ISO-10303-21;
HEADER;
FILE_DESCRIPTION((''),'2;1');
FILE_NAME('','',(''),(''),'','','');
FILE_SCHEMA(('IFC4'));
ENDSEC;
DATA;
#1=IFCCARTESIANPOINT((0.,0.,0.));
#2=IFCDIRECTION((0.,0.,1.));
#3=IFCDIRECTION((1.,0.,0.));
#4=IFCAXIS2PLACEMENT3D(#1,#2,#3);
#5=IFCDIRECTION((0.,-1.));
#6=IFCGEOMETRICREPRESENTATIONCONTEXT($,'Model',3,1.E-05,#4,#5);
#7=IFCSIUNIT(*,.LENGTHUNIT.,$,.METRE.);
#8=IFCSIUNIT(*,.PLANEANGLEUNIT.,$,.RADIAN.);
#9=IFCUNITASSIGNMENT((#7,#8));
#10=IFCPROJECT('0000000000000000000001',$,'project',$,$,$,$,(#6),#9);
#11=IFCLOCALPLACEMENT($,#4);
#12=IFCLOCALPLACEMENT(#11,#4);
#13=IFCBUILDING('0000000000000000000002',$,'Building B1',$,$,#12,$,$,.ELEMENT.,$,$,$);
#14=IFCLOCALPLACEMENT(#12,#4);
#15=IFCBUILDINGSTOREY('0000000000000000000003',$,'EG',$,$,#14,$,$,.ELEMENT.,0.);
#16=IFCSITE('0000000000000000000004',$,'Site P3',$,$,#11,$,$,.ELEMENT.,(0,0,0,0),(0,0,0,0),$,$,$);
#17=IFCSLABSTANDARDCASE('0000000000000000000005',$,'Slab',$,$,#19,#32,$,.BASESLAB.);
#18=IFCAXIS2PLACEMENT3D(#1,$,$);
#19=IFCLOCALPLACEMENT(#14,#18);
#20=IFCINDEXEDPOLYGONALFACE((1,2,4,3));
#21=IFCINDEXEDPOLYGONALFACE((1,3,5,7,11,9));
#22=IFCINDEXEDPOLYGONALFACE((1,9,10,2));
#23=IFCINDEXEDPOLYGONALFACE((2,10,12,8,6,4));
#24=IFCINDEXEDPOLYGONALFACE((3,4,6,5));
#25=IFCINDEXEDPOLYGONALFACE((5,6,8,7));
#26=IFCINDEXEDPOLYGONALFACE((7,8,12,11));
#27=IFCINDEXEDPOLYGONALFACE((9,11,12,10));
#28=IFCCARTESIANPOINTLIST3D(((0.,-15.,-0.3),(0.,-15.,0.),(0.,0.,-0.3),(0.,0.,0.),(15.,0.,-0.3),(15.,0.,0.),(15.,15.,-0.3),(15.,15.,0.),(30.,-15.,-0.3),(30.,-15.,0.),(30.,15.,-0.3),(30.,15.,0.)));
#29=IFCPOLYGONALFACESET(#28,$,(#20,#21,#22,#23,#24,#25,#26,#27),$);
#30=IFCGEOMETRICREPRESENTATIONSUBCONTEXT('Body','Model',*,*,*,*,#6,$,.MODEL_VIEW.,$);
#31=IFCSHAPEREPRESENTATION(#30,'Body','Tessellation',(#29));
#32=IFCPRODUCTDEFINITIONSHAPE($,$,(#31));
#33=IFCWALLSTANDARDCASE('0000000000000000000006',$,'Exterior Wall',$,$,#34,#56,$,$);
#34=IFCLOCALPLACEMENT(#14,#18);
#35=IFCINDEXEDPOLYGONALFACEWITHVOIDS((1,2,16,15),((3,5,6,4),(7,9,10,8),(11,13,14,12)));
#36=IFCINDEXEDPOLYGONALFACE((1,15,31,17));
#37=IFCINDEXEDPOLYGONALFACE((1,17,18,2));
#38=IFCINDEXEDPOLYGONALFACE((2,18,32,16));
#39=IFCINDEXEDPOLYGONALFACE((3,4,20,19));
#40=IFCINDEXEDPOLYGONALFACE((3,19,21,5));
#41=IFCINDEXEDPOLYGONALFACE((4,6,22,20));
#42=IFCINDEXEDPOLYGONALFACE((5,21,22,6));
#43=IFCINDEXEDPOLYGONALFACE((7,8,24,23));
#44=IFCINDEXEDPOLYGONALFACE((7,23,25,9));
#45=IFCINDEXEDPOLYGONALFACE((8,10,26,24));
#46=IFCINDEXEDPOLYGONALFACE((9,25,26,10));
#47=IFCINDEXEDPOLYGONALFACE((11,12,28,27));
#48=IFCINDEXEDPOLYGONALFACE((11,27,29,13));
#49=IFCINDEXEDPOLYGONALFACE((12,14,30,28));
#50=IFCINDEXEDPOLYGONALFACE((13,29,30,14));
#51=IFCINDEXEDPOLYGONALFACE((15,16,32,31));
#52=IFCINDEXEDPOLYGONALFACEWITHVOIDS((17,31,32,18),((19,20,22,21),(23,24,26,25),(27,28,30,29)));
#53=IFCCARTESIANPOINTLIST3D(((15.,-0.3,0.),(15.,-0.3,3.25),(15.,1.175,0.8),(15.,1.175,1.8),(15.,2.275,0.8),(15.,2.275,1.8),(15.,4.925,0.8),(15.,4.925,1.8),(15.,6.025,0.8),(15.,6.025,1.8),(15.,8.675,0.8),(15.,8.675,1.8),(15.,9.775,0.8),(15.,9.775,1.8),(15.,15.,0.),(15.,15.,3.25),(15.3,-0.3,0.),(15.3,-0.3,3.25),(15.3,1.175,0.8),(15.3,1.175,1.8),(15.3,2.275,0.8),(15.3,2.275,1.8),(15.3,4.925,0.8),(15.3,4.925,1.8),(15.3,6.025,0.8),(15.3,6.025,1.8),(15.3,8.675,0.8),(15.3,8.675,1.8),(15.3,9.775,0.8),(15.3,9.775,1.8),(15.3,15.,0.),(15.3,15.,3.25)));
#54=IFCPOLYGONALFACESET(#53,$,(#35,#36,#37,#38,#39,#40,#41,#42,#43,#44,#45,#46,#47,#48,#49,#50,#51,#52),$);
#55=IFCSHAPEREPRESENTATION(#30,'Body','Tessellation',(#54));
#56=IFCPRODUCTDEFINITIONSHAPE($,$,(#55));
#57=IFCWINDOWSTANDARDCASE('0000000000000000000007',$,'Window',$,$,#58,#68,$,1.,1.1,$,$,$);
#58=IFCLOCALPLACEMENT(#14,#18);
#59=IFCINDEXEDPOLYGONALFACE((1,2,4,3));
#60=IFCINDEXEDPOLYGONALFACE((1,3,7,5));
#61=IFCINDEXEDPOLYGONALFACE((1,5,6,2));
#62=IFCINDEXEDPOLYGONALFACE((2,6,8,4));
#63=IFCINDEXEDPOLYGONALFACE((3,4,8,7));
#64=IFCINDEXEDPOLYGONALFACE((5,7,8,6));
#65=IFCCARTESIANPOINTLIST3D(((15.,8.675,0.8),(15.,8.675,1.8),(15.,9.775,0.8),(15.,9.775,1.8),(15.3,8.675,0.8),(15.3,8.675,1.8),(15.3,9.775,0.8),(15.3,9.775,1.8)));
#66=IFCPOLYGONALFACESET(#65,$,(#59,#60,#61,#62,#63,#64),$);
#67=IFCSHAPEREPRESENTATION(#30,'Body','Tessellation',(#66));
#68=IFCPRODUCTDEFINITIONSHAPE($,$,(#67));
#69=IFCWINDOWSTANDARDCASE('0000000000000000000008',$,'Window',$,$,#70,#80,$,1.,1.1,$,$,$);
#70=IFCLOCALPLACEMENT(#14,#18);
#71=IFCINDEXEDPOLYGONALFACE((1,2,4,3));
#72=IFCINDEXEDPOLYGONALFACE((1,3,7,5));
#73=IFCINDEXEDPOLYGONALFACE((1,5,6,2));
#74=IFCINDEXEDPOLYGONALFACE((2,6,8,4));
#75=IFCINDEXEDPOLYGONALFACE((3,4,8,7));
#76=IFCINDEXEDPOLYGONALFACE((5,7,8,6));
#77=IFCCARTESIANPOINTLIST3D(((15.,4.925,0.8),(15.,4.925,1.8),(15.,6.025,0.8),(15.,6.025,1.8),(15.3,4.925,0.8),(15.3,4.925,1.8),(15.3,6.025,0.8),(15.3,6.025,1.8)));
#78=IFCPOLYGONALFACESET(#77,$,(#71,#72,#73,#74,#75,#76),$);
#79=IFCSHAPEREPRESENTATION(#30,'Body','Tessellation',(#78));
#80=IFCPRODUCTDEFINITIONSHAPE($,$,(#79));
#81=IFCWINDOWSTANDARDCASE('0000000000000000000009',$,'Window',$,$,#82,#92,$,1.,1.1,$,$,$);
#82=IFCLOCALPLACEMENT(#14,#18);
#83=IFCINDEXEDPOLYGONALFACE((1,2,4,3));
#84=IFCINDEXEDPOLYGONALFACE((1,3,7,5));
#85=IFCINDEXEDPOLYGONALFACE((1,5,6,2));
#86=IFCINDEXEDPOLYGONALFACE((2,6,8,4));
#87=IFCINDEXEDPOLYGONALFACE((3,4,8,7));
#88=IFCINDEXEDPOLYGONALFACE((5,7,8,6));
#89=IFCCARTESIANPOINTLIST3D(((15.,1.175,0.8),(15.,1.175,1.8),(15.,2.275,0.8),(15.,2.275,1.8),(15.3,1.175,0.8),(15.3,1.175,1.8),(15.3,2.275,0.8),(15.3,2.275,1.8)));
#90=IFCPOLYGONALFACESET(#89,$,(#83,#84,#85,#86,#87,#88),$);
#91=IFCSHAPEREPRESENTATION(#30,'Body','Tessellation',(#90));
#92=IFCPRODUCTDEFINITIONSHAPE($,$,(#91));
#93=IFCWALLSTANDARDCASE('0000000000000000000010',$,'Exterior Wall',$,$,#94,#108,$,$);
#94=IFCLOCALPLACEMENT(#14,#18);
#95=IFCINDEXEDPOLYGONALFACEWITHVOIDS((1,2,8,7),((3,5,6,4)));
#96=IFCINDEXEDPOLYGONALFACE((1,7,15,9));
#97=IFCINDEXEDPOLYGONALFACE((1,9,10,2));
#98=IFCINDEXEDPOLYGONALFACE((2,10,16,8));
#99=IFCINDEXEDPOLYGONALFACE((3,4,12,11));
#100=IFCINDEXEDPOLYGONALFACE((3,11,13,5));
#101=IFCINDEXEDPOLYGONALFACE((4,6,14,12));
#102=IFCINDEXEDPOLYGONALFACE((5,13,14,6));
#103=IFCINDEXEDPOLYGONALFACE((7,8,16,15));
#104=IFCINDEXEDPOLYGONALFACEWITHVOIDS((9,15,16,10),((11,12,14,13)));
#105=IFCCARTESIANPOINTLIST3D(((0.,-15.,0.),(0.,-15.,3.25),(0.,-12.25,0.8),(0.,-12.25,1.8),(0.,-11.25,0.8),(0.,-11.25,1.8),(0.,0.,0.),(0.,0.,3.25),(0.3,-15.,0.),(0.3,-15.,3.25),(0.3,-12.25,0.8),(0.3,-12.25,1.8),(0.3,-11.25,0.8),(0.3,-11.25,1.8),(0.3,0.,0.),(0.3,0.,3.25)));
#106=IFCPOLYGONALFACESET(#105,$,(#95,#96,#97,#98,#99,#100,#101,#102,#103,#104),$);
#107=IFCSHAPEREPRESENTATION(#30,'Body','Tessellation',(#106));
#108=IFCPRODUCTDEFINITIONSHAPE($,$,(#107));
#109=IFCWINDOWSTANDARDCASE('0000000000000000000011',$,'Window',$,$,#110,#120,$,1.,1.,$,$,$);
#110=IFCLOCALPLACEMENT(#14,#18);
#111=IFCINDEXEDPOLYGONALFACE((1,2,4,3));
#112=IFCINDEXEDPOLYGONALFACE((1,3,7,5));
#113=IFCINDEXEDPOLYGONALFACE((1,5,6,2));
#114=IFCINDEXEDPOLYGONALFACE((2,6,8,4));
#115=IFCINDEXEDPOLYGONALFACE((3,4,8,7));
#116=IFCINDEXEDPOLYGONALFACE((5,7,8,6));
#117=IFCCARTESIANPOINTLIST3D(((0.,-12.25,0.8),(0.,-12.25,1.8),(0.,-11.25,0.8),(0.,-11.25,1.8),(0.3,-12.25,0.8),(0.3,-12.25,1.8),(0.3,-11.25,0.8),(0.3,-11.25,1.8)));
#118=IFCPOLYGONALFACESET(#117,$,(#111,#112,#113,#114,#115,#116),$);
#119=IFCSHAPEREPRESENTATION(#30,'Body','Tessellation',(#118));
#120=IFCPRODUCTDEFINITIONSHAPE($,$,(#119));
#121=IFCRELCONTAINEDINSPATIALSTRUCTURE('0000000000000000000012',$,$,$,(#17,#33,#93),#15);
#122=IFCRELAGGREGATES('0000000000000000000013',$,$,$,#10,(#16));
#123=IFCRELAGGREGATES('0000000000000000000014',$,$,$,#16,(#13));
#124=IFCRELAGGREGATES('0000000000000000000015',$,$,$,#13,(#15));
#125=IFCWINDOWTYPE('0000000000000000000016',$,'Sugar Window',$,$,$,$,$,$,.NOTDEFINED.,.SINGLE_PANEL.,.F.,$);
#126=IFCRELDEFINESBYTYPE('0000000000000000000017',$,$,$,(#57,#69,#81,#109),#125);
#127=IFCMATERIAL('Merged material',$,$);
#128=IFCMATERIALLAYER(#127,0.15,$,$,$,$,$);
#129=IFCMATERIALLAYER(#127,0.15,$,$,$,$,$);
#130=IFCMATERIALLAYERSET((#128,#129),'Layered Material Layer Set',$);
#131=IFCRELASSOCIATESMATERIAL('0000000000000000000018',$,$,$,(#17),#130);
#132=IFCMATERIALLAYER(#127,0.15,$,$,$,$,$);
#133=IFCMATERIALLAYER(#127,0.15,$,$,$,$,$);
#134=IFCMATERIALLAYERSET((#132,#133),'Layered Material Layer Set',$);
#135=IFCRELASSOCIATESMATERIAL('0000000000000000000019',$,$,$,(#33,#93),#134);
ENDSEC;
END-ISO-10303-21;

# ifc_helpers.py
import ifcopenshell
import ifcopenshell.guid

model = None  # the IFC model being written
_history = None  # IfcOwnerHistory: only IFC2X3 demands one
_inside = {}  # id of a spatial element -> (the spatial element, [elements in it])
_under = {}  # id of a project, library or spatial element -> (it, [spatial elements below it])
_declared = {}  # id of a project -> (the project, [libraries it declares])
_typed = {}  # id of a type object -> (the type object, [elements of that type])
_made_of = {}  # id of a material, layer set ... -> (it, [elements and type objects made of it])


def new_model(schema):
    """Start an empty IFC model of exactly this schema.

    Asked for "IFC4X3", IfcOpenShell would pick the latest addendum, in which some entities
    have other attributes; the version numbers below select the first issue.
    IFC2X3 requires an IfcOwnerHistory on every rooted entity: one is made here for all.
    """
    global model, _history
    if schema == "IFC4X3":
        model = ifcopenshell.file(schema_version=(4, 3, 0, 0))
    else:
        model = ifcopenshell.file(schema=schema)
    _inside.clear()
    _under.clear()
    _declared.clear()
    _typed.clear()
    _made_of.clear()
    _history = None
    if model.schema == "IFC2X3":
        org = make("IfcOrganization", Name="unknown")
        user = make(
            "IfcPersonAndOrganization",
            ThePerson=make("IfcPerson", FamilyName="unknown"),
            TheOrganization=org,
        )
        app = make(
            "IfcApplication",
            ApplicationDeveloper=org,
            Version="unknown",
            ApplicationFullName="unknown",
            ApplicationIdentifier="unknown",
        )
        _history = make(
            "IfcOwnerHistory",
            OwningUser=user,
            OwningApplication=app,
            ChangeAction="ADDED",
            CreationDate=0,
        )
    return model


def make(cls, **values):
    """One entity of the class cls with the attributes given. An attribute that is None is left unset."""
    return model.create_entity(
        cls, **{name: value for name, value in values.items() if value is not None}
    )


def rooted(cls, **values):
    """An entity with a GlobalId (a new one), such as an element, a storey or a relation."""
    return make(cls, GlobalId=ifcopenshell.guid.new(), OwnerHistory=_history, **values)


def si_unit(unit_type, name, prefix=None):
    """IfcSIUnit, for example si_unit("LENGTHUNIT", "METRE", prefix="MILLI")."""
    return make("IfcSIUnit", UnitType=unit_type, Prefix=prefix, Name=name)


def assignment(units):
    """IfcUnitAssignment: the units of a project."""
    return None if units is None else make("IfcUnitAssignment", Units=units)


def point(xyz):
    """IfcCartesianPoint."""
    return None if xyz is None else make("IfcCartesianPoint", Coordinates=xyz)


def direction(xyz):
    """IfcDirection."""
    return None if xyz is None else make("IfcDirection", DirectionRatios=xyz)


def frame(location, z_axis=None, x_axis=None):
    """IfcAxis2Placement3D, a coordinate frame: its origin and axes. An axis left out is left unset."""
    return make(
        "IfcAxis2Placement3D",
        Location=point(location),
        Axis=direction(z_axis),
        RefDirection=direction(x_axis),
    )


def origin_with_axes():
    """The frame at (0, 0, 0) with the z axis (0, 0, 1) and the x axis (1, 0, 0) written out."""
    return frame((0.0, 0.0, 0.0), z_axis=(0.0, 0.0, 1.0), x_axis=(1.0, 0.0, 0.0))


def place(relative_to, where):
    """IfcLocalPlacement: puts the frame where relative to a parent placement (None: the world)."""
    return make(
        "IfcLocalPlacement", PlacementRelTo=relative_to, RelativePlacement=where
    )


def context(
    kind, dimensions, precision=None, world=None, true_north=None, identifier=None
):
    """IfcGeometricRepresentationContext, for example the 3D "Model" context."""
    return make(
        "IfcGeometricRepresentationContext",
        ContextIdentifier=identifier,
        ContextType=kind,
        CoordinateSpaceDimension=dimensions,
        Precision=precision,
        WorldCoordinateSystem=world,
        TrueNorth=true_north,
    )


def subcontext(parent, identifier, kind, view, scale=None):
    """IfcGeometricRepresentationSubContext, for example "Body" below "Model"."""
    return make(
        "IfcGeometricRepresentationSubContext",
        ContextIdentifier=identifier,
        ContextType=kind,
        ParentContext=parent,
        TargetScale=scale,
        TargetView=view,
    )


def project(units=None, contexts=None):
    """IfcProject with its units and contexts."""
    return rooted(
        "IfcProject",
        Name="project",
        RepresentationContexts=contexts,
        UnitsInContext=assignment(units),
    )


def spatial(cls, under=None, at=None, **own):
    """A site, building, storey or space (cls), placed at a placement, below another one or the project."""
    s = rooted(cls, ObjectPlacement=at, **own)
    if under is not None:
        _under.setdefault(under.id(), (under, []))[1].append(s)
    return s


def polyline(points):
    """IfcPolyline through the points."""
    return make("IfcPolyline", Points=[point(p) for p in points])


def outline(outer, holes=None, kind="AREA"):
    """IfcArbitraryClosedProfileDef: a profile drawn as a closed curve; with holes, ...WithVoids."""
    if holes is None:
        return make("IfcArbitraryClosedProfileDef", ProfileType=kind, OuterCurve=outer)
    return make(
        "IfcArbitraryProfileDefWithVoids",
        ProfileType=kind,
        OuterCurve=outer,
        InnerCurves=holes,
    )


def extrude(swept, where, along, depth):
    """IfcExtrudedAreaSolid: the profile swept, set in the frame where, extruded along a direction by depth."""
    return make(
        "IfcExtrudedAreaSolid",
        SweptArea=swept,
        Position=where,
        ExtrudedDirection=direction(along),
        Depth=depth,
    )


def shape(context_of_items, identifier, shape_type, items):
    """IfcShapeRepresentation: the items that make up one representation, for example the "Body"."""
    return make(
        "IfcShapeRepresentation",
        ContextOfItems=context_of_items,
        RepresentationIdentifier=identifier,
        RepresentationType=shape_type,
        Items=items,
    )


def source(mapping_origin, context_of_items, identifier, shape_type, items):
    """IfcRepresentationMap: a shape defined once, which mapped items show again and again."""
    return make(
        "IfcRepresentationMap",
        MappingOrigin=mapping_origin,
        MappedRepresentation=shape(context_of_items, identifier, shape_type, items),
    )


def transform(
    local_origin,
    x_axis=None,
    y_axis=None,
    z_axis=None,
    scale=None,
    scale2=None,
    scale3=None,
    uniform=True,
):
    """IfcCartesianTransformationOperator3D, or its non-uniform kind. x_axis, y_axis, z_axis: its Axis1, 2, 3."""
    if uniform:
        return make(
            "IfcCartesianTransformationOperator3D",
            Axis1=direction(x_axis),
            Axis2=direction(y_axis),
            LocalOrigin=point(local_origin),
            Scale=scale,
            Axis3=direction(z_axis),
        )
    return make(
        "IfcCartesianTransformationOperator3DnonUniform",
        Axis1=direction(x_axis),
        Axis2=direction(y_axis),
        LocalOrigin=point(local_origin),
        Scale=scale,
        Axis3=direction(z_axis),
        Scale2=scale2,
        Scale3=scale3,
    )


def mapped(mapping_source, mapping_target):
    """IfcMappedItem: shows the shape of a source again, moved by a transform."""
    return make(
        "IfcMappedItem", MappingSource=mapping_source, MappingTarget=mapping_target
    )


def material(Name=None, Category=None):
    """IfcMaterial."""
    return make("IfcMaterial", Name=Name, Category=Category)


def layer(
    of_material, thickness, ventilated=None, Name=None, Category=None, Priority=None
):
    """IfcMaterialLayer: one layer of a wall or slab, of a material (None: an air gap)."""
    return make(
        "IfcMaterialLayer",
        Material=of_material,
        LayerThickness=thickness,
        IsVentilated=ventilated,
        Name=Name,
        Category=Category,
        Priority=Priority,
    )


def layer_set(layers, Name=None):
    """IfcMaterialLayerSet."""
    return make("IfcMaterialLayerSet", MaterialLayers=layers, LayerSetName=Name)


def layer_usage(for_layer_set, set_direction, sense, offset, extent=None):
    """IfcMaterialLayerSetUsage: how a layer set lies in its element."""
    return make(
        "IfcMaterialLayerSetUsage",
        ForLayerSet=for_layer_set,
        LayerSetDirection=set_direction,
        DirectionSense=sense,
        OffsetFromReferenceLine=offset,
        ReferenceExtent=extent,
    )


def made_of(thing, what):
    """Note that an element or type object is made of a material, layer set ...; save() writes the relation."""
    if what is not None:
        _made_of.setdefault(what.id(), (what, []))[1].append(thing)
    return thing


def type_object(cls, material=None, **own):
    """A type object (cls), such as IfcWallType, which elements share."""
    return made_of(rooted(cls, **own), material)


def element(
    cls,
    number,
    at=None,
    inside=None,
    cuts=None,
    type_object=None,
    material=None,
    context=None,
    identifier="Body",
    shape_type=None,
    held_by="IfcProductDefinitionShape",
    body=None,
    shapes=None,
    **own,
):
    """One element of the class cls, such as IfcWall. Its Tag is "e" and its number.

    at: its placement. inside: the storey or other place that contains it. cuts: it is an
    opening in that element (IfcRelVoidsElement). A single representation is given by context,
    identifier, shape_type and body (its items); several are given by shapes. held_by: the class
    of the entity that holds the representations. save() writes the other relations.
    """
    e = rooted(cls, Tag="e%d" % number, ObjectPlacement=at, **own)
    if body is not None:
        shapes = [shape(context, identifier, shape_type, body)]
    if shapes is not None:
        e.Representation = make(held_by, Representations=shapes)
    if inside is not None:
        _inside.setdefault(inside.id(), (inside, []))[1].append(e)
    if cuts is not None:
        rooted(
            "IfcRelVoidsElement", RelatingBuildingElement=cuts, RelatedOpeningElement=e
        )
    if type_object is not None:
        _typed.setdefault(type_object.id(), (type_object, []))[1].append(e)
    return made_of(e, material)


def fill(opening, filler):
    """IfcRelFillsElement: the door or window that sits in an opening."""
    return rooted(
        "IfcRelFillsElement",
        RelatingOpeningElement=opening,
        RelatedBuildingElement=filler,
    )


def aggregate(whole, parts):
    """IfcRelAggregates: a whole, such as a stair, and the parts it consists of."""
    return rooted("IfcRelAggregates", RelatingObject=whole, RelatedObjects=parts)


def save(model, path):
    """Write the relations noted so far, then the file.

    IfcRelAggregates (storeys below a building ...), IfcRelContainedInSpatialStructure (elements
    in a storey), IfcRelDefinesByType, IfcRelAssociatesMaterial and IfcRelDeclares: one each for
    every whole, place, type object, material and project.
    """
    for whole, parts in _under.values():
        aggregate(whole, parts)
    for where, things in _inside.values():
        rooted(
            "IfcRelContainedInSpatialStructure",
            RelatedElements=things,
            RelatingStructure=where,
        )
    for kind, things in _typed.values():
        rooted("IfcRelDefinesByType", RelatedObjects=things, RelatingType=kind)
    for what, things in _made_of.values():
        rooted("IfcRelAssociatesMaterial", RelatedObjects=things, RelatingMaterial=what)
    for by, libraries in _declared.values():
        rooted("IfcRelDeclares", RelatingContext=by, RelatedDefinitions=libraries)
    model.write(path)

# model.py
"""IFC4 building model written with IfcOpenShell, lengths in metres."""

from ifc_helpers import new_model, si_unit, direction, frame, origin_with_axes, place, context, subcontext, project, spatial, polyline, outline, extrude, source, transform, mapped, material, layer, layer_set, layer_usage, type_object, element, fill, save


model = new_model("IFC4")

# Units and contexts
model_context = context("Model", 3, precision=1e-05, world=origin_with_axes(), true_north=direction((0.0, -1.0)))
body_context = subcontext(model_context, "Body", "Model", "MODEL_VIEW")
ifc_project = project(units=[si_unit("LENGTHUNIT", "METRE"), si_unit("PLANEANGLEUNIT", "RADIAN")], contexts=[model_context])

# Site, building, storey
site_placement = place(None, origin_with_axes())
site = spatial("IfcSite", under=ifc_project, at=site_placement, Name="Site P3", CompositionType="ELEMENT", RefLatitude=(0, 0, 0, 0), RefLongitude=(0, 0, 0, 0))
building_placement = place(site_placement, origin_with_axes())
building = spatial("IfcBuilding", under=site, at=building_placement, Name="Building B1", CompositionType="ELEMENT")
storey_placement = place(building_placement, origin_with_axes())
storey = spatial("IfcBuildingStorey", under=building, at=storey_placement, Name="EG", CompositionType="ELEMENT", Elevation=0.0)

# Slab
ifc_material = material(Name="Merged material")
ifc_layer_1 = layer(ifc_material, 0.15)
ifc_layer_2 = layer(ifc_material, 0.15)
ifc_layer_set_1 = layer_set([ifc_layer_1, ifc_layer_2], Name="Layered Material Layer Set")
ifc_layer_usage_1 = layer_usage(ifc_layer_set_1, "AXIS2", "POSITIVE", -0.15)
slab_placement = place(storey_placement, origin_with_axes())
element("IfcSlabStandardCase", 1, at=slab_placement, inside=storey, material=ifc_layer_usage_1, Name="Slab", PredefinedType="BASESLAB", context=body_context, shape_type="SweptSolid", body=[
    extrude(outline(polyline([(0.0, -15.0), (30.0, -15.0), (30.0, 15.0), (15.0, 15.0), (15.0, 0.0), (0.0, 0.0), (0.0, -15.0)])), frame((0.0, 0.0, -0.3), z_axis=(0.0, 0.0, 1.0), x_axis=(1.0, 0.0, 0.0)), (0.0, 0.0, 1.0), 0.3),
])

# Wall, openings, windows
ifc_layer_3 = layer(ifc_material, 0.15)
ifc_layer_4 = layer(ifc_material, 0.15)
ifc_layer_set_2 = layer_set([ifc_layer_3, ifc_layer_4], Name="Layered Material Layer Set")
ifc_layer_usage_2 = layer_usage(ifc_layer_set_2, "AXIS2", "POSITIVE", -0.15)
wall_1_placement = place(storey_placement, frame((15.15, 15.0, 0.0), z_axis=(0.0, 0.0, 1.0), x_axis=(0.0, -1.0, 0.0)))
wall_1 = element("IfcWallStandardCase", 2, at=wall_1_placement, inside=storey, material=ifc_layer_usage_2, Name="Exterior Wall", context=body_context, shape_type="SweptSolid", body=[
    extrude(outline(polyline([(0.0, 0.15), (15.3, 0.15), (15.3, -0.15), (0.0, -0.15), (0.0, 0.15)])), origin_with_axes(), (0.0, 0.0, 1.0), 3.25),
])
opening_1_placement = place(wall_1_placement, frame((5.225, 0.0, 0.8), z_axis=(0.0, 0.0, 1.0), x_axis=(1.0, 0.0, 0.0)))
opening_1 = element("IfcOpeningStandardCase", 3, at=opening_1_placement, cuts=wall_1, context=body_context, shape_type="SweptSolid", body=[
    extrude(outline(polyline([(0.0, 0.0), (0.0, 1.1), (1.0, 1.1), (1.0, 0.0), (0.0, 0.0)])), frame((0.0, -0.15, 0.0), z_axis=(0.0, 1.0, 0.0), x_axis=(0.0, 0.0, 1.0)), (0.0, 0.0, 1.0), 0.3),
])
opening_2_placement = place(wall_1_placement, frame((8.975, 0.0, 0.8), z_axis=(0.0, 0.0, 1.0), x_axis=(1.0, 0.0, 0.0)))
opening_2 = element("IfcOpeningStandardCase", 4, at=opening_2_placement, cuts=wall_1, context=body_context, shape_type="SweptSolid", body=[
    extrude(outline(polyline([(0.0, 0.0), (0.0, 1.1), (1.0, 1.1), (1.0, 0.0), (0.0, 0.0)])), frame((0.0, -0.15, 0.0), z_axis=(0.0, 1.0, 0.0), x_axis=(0.0, 0.0, 1.0)), (0.0, 0.0, 1.0), 0.3),
])
opening_3_placement = place(wall_1_placement, frame((12.725, 0.0, 0.8), z_axis=(0.0, 0.0, 1.0), x_axis=(1.0, 0.0, 0.0)))
opening_3 = element("IfcOpeningStandardCase", 5, at=opening_3_placement, cuts=wall_1, context=body_context, shape_type="SweptSolid", body=[
    extrude(outline(polyline([(0.0, 0.0), (0.0, 1.1), (1.0, 1.1), (1.0, 0.0), (0.0, 0.0)])), frame((0.0, -0.15, 0.0), z_axis=(0.0, 1.0, 0.0), x_axis=(0.0, 0.0, 1.0)), (0.0, 0.0, 1.0), 0.3),
])
window_type = type_object("IfcWindowType", Name="Sugar Window", ParameterTakesPrecedence=False, PartitioningType="SINGLE_PANEL", PredefinedType="NOTDEFINED")
shared_shape_1 = source(origin_with_axes(), body_context, "Body", "SweptSolid", [
    extrude(outline(polyline([(0.0, 0.0), (0.0, 1.1), (1.0, 1.1), (1.0, 0.0), (0.0, 0.0)])), frame((0.0, -0.15, 0.0), z_axis=(0.0, 1.0, 0.0), x_axis=(0.0, 0.0, 1.0)), (0.0, 0.0, 1.0), 0.3),
])
window_1_placement = place(opening_1_placement, origin_with_axes())
window_1 = element("IfcWindowStandardCase", 6, at=window_1_placement, type_object=window_type, Name="Window", OverallHeight=1.0, OverallWidth=1.1, context=body_context, shape_type="MappedRepresentation", body=[
    mapped(shared_shape_1, transform((0.0, 0.0, 0.0))),
])
fill(opening_1, window_1)
window_2_placement = place(opening_2_placement, origin_with_axes())
window_2 = element("IfcWindowStandardCase", 7, at=window_2_placement, type_object=window_type, Name="Window", OverallHeight=1.0, OverallWidth=1.1, context=body_context, shape_type="MappedRepresentation", body=[
    mapped(shared_shape_1, transform((0.0, 0.0, 0.0))),
])
fill(opening_2, window_2)
window_3_placement = place(opening_3_placement, origin_with_axes())
window_3 = element("IfcWindowStandardCase", 8, at=window_3_placement, type_object=window_type, Name="Window", OverallHeight=1.0, OverallWidth=1.1, context=body_context, shape_type="MappedRepresentation", body=[
    mapped(shared_shape_1, transform((0.0, 0.0, 0.0))),
])
fill(opening_3, window_3)

# Wall, opening, window
wall_2_placement = place(storey_placement, frame((0.15, 0.0, 0.0), z_axis=(0.0, 0.0, 1.0), x_axis=(0.0, -1.0, 0.0)))
wall_2 = element("IfcWallStandardCase", 9, at=wall_2_placement, inside=storey, material=ifc_layer_usage_2, Name="Exterior Wall", context=body_context, shape_type="SweptSolid", body=[
    extrude(outline(polyline([(0.0, 0.15), (15.0, 0.15), (15.0, -0.15), (0.0, -0.15), (0.0, 0.15)])), origin_with_axes(), (0.0, 0.0, 1.0), 3.25),
])
opening_4_placement = place(wall_2_placement, frame((11.25, 0.0, 0.8), z_axis=(0.0, 0.0, 1.0), x_axis=(1.0, 0.0, 0.0)))
opening_4 = element("IfcOpeningStandardCase", 10, at=opening_4_placement, cuts=wall_2, context=body_context, shape_type="SweptSolid", body=[
    extrude(outline(polyline([(0.0, 0.0), (0.0, 1.0), (1.0, 1.0), (1.0, 0.0), (0.0, 0.0)])), frame((0.0, -0.15, 0.0), z_axis=(0.0, 1.0, 0.0), x_axis=(0.0, 0.0, 1.0)), (0.0, 0.0, 1.0), 0.3),
])
shared_shape_2 = source(origin_with_axes(), body_context, "Body", "SweptSolid", [
    extrude(outline(polyline([(0.0, 0.0), (0.0, 1.0), (1.0, 1.0), (1.0, 0.0), (0.0, 0.0)])), frame((0.0, -0.15, 0.0), z_axis=(0.0, 1.0, 0.0), x_axis=(0.0, 0.0, 1.0)), (0.0, 0.0, 1.0), 0.3),
])
window_4_placement = place(opening_4_placement, origin_with_axes())
window_4 = element("IfcWindowStandardCase", 11, at=window_4_placement, type_object=window_type, Name="Window", OverallHeight=1.0, OverallWidth=1.0, context=body_context, shape_type="MappedRepresentation", body=[
    mapped(shared_shape_2, transform((0.0, 0.0, 0.0))),
])
fill(opening_4, window_4)

save(model, "model.ifc")
